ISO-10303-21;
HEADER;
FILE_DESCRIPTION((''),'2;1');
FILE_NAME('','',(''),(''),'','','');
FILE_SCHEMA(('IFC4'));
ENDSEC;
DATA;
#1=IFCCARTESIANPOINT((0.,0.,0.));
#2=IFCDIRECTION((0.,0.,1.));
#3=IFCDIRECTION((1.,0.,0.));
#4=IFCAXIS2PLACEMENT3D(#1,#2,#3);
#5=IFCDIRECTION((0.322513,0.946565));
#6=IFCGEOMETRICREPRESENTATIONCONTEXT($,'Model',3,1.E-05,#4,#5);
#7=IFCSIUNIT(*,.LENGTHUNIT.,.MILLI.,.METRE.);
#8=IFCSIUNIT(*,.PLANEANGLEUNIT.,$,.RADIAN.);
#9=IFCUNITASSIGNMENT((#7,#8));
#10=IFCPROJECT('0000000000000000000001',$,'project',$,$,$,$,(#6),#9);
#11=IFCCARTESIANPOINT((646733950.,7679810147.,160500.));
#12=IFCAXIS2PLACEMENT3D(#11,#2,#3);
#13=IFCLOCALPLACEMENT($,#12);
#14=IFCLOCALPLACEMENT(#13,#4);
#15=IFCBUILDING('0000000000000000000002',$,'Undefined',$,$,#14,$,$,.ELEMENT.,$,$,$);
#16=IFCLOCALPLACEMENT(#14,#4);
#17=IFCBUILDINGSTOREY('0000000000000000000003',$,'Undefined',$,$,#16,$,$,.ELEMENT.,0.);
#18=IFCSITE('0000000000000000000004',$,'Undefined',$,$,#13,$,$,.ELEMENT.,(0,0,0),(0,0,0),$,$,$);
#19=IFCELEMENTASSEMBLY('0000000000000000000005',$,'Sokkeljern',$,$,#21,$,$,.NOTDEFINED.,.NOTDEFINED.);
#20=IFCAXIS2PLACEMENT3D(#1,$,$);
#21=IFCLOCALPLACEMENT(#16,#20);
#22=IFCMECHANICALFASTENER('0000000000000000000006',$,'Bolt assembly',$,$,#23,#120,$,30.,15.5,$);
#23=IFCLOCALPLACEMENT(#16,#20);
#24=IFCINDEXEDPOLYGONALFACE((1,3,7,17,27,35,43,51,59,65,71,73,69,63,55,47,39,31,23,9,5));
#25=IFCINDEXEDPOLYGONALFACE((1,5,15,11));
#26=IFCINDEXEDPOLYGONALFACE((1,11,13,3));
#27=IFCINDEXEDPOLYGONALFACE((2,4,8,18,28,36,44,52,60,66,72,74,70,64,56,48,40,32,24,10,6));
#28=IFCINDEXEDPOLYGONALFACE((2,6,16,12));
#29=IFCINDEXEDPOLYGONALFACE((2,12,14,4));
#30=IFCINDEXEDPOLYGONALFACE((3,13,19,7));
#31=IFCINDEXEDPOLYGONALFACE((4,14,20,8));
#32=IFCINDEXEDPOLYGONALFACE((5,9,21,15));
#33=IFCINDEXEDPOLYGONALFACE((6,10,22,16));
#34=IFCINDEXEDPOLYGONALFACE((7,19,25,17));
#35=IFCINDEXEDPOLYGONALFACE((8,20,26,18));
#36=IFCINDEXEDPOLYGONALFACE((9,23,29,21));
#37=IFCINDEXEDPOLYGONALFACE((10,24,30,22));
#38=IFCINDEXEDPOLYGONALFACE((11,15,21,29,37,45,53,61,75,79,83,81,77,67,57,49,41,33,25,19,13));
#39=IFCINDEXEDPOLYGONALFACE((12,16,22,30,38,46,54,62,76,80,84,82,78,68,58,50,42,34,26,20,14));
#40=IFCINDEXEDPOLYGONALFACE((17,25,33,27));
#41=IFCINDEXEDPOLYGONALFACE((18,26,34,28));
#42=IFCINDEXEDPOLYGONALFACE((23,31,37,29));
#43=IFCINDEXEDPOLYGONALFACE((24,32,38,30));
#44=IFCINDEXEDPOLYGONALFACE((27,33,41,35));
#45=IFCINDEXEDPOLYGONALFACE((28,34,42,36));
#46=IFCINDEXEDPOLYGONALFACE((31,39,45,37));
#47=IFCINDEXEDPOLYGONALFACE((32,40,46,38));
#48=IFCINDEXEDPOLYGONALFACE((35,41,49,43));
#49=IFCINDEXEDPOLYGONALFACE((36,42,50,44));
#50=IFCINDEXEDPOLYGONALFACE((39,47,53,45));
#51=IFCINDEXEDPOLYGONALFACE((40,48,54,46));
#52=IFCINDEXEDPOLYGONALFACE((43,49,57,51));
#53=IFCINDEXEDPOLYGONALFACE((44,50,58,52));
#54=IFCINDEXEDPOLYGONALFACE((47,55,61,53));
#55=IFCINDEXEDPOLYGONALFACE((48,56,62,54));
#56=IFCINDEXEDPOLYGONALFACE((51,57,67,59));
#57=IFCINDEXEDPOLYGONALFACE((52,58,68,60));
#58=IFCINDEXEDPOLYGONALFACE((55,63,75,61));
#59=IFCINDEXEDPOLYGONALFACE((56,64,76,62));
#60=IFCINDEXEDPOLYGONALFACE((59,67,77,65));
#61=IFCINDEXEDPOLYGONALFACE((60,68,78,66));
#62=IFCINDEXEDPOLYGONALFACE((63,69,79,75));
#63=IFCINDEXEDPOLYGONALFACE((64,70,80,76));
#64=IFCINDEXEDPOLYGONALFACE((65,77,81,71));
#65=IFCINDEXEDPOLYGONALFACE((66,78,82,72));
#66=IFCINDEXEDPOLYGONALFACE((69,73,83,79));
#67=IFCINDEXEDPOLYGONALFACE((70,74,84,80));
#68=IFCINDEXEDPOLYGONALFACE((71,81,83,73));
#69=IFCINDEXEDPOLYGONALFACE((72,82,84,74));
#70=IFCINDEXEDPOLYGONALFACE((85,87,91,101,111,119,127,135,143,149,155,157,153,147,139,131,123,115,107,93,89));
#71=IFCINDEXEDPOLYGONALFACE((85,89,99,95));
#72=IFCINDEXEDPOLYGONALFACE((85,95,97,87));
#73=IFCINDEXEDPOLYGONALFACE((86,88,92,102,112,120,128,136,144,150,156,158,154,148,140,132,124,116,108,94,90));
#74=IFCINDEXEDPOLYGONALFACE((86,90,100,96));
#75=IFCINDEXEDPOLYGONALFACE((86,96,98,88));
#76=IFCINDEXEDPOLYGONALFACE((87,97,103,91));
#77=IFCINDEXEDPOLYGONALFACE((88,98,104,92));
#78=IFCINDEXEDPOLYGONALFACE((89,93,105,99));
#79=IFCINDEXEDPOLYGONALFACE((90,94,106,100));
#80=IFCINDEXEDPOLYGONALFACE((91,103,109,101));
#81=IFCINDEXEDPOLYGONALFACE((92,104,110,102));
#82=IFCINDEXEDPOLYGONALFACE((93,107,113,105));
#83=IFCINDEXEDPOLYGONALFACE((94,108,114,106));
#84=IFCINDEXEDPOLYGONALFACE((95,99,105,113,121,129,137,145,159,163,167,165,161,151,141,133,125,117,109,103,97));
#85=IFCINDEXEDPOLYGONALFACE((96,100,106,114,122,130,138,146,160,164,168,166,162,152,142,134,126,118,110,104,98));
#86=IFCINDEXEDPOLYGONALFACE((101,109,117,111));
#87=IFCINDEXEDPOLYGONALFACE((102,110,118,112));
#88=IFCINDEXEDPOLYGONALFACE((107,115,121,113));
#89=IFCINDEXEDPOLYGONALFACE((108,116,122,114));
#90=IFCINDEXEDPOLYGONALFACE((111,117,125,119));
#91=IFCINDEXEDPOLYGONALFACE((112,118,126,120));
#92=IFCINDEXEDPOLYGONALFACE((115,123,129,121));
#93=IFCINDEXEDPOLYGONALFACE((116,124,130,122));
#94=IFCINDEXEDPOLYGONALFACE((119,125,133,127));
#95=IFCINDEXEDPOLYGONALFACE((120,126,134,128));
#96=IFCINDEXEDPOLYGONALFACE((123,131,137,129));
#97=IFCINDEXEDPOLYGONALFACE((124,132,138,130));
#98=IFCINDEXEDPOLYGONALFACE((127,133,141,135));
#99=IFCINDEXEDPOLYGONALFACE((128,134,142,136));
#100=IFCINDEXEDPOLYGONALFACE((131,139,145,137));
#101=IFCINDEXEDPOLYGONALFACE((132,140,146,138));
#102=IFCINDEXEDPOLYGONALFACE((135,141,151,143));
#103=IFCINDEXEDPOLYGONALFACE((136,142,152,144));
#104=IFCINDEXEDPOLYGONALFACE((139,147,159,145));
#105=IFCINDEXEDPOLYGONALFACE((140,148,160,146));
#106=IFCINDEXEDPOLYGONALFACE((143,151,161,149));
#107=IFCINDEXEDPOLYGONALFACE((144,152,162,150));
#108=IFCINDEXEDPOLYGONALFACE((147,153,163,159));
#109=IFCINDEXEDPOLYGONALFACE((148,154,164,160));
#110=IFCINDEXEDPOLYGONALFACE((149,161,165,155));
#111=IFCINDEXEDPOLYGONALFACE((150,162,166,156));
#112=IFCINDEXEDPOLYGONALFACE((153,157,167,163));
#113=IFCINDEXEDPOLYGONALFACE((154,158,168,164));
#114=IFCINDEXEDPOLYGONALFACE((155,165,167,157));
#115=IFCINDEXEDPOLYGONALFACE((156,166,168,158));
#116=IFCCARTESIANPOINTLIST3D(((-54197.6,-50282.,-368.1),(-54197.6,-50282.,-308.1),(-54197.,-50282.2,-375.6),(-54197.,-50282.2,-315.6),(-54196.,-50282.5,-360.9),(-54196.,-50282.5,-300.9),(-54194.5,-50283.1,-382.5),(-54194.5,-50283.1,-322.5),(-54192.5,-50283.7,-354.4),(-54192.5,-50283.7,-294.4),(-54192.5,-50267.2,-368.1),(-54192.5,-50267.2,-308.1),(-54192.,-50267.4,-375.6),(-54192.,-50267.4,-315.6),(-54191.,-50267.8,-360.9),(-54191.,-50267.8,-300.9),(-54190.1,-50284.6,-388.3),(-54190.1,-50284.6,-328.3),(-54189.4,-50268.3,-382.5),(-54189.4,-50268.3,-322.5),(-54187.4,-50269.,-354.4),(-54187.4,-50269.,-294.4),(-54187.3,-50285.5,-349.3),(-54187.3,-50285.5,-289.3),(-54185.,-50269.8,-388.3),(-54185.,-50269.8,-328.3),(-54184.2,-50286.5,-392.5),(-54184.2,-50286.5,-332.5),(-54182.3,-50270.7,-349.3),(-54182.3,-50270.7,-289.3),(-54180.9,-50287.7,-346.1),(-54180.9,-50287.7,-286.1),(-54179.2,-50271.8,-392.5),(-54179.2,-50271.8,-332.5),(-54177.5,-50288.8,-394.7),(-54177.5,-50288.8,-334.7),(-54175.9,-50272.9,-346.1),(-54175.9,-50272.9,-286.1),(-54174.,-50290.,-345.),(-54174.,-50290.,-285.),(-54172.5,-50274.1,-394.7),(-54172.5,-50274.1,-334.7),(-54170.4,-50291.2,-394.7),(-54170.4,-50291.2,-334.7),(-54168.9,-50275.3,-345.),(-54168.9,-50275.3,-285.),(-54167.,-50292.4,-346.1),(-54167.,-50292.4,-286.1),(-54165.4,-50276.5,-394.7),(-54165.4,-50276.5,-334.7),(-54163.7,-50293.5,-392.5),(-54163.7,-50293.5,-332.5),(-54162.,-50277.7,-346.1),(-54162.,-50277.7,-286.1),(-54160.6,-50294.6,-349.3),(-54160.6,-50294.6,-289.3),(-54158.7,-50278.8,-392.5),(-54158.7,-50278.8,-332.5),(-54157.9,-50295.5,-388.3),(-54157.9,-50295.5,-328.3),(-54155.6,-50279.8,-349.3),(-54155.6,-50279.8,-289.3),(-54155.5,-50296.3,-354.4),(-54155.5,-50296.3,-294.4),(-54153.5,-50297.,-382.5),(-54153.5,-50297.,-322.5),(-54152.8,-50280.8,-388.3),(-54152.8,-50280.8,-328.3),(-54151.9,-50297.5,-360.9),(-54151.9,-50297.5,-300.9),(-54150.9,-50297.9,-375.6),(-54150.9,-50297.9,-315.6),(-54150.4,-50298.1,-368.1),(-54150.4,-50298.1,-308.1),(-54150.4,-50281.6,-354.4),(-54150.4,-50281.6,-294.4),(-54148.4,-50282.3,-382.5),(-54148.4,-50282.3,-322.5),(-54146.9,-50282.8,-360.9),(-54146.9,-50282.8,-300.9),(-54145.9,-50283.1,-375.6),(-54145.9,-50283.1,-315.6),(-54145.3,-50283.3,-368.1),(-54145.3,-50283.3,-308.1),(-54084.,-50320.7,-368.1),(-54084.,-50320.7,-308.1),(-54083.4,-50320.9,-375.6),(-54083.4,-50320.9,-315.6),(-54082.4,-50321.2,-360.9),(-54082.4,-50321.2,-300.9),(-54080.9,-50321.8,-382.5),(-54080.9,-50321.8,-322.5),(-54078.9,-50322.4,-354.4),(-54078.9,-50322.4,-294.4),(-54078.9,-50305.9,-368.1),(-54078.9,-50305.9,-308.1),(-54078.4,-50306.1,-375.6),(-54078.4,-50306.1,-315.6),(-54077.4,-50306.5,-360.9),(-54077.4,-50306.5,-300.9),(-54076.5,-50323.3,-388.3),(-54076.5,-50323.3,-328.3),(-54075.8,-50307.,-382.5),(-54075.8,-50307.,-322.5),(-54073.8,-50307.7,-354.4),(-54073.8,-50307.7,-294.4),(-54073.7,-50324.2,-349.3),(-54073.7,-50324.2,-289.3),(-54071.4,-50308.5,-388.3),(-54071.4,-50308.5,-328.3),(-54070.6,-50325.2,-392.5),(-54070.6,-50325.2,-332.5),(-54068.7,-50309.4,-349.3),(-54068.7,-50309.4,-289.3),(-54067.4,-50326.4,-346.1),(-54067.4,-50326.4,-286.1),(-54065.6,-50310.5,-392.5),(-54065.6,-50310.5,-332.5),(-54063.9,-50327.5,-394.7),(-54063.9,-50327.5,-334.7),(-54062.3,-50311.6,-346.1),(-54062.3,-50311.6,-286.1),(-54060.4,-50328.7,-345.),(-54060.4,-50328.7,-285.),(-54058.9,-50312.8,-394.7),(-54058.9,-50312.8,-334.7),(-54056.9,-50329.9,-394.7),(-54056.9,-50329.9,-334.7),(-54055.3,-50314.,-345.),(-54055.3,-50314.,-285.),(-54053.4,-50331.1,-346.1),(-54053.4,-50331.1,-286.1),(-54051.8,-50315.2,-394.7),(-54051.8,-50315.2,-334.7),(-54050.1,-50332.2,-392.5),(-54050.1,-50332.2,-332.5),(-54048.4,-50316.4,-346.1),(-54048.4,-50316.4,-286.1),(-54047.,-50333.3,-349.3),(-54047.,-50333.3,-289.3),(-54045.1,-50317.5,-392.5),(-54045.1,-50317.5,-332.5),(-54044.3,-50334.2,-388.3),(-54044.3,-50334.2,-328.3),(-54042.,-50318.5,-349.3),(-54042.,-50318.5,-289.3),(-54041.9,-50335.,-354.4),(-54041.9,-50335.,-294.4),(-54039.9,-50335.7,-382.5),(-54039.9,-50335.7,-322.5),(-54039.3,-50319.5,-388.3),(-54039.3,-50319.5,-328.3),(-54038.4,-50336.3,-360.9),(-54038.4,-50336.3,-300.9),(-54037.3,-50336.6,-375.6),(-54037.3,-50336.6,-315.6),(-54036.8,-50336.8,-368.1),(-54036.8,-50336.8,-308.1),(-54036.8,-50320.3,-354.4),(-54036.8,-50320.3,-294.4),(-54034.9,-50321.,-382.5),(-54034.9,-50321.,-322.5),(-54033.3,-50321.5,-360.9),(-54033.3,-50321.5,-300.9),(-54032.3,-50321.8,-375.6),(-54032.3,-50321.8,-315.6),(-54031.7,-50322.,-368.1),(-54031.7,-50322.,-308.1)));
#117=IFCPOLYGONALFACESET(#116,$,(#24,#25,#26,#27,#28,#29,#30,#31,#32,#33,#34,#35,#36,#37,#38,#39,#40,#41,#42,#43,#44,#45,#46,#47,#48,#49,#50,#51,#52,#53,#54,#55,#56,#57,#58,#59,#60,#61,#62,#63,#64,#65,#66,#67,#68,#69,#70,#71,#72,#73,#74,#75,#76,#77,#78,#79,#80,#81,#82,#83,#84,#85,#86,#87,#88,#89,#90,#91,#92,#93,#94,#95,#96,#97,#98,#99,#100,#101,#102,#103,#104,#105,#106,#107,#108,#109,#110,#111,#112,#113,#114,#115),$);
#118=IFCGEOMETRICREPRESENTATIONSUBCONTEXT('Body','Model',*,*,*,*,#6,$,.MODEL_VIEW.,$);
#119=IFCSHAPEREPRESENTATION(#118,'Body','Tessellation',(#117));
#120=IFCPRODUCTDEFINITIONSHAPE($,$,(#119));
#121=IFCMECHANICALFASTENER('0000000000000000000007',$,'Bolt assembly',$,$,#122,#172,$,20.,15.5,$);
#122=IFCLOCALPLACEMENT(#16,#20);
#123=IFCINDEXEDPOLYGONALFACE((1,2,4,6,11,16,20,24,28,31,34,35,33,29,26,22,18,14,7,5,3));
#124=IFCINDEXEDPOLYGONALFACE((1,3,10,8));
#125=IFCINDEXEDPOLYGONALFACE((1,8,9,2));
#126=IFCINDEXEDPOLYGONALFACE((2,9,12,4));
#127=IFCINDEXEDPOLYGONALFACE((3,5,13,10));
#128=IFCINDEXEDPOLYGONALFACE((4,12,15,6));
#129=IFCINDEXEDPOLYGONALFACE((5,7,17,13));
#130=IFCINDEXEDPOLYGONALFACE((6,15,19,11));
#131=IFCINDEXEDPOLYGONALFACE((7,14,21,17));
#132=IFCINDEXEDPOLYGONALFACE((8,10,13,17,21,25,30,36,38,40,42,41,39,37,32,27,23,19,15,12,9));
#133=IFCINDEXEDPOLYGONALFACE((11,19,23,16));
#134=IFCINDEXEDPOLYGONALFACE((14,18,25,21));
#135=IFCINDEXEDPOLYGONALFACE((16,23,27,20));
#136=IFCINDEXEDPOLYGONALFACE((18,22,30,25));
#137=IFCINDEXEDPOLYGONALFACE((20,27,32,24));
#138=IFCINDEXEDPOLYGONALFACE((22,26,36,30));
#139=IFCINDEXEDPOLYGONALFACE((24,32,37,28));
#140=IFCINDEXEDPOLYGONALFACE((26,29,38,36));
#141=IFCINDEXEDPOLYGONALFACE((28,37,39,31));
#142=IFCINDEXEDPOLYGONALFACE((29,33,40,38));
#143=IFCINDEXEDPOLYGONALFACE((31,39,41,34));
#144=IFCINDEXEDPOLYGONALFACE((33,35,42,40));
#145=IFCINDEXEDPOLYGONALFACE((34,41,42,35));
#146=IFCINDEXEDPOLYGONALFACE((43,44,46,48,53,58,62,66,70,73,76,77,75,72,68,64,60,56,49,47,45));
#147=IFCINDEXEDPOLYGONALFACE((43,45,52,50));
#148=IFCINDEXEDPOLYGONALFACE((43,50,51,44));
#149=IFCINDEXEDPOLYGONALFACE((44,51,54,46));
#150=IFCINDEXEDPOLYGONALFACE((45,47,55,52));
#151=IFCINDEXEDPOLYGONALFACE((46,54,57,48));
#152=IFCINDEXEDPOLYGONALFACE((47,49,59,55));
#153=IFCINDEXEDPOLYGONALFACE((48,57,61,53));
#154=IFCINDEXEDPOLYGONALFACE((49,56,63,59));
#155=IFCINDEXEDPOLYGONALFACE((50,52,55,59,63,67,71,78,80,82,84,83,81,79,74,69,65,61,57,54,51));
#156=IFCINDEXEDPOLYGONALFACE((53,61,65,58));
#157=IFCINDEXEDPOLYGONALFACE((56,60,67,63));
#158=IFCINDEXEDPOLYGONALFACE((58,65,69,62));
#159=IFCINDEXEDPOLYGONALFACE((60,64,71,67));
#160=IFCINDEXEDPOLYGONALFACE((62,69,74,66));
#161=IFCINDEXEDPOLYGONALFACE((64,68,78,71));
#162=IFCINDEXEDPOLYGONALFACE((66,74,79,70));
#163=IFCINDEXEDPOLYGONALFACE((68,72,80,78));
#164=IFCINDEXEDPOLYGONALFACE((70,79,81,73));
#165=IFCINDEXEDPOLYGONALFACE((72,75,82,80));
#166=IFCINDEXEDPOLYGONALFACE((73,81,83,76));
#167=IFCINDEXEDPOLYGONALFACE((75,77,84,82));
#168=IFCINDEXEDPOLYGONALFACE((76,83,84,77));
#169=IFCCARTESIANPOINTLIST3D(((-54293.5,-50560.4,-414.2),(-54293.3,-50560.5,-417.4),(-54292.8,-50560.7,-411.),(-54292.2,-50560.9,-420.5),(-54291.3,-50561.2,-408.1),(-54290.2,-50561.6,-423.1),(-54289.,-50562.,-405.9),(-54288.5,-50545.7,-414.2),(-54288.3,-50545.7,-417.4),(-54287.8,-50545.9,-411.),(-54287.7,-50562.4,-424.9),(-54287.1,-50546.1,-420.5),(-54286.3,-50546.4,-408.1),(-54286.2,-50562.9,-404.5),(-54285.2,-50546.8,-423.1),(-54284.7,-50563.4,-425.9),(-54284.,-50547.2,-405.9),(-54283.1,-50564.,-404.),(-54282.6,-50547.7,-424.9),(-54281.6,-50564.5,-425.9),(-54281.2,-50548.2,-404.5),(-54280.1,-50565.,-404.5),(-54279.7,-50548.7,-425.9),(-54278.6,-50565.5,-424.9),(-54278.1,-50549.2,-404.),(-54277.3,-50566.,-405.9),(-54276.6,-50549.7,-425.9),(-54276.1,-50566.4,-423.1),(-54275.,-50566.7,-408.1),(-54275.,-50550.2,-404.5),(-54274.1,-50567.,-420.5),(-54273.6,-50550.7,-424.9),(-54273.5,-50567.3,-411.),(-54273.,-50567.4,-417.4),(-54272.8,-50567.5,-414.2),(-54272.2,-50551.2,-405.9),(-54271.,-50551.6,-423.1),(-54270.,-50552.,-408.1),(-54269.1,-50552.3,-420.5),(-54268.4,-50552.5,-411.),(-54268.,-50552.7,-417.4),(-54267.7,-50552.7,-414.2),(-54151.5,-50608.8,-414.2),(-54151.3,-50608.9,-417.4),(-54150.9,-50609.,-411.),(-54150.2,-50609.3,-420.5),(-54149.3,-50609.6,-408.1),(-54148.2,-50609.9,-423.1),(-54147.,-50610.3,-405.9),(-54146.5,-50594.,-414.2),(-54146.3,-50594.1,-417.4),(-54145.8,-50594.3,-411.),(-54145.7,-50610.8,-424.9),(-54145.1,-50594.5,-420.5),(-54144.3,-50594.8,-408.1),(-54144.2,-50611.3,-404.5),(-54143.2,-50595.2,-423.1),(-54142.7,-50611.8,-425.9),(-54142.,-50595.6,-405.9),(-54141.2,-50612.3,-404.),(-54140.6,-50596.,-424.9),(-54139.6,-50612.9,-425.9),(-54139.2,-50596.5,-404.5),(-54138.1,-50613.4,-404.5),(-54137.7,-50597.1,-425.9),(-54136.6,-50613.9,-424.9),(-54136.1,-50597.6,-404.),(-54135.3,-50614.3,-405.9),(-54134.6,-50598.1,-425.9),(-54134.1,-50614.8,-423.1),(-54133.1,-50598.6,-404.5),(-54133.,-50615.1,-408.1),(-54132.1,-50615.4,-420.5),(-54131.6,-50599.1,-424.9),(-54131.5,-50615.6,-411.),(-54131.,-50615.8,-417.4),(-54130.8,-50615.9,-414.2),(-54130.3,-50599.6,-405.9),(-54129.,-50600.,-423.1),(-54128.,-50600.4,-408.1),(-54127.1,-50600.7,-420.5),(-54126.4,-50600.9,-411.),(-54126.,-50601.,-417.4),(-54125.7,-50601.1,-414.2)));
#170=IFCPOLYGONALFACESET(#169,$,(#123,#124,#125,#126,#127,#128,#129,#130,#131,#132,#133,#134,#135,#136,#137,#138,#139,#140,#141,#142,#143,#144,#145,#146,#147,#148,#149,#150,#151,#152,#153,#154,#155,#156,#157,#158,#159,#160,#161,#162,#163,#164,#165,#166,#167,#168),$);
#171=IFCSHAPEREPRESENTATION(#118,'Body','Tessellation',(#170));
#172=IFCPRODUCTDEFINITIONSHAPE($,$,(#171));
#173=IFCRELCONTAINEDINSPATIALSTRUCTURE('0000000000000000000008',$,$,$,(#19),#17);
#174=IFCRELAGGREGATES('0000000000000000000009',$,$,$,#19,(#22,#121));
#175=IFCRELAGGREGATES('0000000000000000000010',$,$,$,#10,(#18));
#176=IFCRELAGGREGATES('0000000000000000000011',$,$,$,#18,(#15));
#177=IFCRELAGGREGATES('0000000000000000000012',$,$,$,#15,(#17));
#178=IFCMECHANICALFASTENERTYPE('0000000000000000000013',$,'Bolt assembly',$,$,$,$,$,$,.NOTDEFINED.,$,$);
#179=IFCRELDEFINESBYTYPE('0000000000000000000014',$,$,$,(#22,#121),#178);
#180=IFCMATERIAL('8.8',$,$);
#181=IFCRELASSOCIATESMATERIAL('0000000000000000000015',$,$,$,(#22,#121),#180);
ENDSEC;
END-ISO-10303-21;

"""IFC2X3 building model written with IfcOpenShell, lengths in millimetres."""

from ifc_helpers import new_model, si_unit, direction, frame, origin_with_axes, origin_2d_with_axis, place, context, subcontext, project, spatial, circle, extrude, source, transform, mapped, material, type_object, element, aggregate, save


model = new_model("IFC2X3")

# Units and contexts
model_context = context("Model", 3, precision=1e-05, world=origin_with_axes(), true_north=direction((0.322513, 0.946565)))
body_context = subcontext(model_context, "Body", "Model", "MODEL_VIEW")
ifc_project = project(units=[si_unit("LENGTHUNIT", "METRE", prefix="MILLI"), si_unit("PLANEANGLEUNIT", "RADIAN")], contexts=[model_context])

# Site, building, storey
site_placement = place(None, frame((646733950.0, 7679810147.0, 160500.0), z_axis=(0.0, 0.0, 1.0), x_axis=(1.0, 0.0, 0.0)))
site = spatial("IfcSite", under=ifc_project, at=site_placement, Name="Undefined", CompositionType="ELEMENT", RefLatitude=(0, 0, 0), RefLongitude=(0, 0, 0))
building_placement = place(site_placement, origin_with_axes())
building = spatial("IfcBuilding", under=site, at=building_placement, Name="Undefined", CompositionType="ELEMENT")
storey_placement = place(building_placement, origin_with_axes())
storey = spatial("IfcBuildingStorey", under=building, at=storey_placement, Name="Undefined", CompositionType="ELEMENT", Elevation=0.0)

# Element assembly
assembly_1_placement = place(storey_placement, origin_with_axes())
assembly_1 = element("IfcElementAssembly", 1, at=assembly_1_placement, inside=storey, Name="Sokkeljern", AssemblyPlace="NOTDEFINED", PredefinedType="NOTDEFINED")

# Mechanical fasteners
ifc_material_1 = material(Name="8.8")
mechanical_fastener_type = type_object("IfcMechanicalFastenerType", Name="Bolt assembly")
shared_shape_1 = source(origin_with_axes(), body_context, "Body", "SweptSolid", [
    extrude(circle(Radius=25.0, at=origin_2d_with_axis()), frame((0.0, 0.0, 0.0), z_axis=(0.0, 1.0, 0.0), x_axis=(1.0, 0.0, 0.0)), (0.0, 0.0, 1.0), 15.6),
])
mechanical_fastener_1_placement = place(assembly_1_placement, frame((-54112.1, -50294.6, -370.0), z_axis=(0.946565, -0.322513, 0.0), x_axis=(0.0, 0.0, 1.0)))
mechanical_fastener_1 = element("IfcMechanicalFastener", 2, at=mechanical_fastener_1_placement, type_object=mechanical_fastener_type, material=ifc_material_1, Name="Bolt assembly", NominalDiameter=30.0, NominalLength=15.5, context=body_context, shape_type="MappedRepresentation", body=[
    mapped(shared_shape_1, transform((0.0, 0.0, -60.0))),
    mapped(shared_shape_1, transform((60.0, 0.0, -60.0))),
    mapped(shared_shape_1, transform((0.0, 0.0, 60.0))),
    mapped(shared_shape_1, transform((60.0, 0.0, 60.0))),
])
shared_shape_2 = source(origin_with_axes(), body_context, "Body", "SweptSolid", [
    extrude(circle(Radius=11.0, at=origin_2d_with_axis()), frame((0.0, -15.5, 0.0), z_axis=(0.0, 1.0, 0.0), x_axis=(1.0, 0.0, 0.0)), (0.0, 0.0, 1.0), 15.6),
])
mechanical_fastener_2_placement = place(assembly_1_placement, frame((-54212.1, -50588.1, -415.0), z_axis=(0.946565, -0.322513, 0.0), x_axis=(0.0, 0.0, 1.0)))
mechanical_fastener_2 = element("IfcMechanicalFastener", 3, at=mechanical_fastener_2_placement, type_object=mechanical_fastener_type, material=ifc_material_1, Name="Bolt assembly", NominalDiameter=20.0, NominalLength=15.5, context=body_context, shape_type="MappedRepresentation", body=[
    mapped(shared_shape_2, transform((0.0, 0.0, -75.0))),
    mapped(shared_shape_2, transform((0.0, 0.0, 75.0))),
])
aggregate(assembly_1, [mechanical_fastener_1, mechanical_fastener_2])

save(model, "model.ifc")
